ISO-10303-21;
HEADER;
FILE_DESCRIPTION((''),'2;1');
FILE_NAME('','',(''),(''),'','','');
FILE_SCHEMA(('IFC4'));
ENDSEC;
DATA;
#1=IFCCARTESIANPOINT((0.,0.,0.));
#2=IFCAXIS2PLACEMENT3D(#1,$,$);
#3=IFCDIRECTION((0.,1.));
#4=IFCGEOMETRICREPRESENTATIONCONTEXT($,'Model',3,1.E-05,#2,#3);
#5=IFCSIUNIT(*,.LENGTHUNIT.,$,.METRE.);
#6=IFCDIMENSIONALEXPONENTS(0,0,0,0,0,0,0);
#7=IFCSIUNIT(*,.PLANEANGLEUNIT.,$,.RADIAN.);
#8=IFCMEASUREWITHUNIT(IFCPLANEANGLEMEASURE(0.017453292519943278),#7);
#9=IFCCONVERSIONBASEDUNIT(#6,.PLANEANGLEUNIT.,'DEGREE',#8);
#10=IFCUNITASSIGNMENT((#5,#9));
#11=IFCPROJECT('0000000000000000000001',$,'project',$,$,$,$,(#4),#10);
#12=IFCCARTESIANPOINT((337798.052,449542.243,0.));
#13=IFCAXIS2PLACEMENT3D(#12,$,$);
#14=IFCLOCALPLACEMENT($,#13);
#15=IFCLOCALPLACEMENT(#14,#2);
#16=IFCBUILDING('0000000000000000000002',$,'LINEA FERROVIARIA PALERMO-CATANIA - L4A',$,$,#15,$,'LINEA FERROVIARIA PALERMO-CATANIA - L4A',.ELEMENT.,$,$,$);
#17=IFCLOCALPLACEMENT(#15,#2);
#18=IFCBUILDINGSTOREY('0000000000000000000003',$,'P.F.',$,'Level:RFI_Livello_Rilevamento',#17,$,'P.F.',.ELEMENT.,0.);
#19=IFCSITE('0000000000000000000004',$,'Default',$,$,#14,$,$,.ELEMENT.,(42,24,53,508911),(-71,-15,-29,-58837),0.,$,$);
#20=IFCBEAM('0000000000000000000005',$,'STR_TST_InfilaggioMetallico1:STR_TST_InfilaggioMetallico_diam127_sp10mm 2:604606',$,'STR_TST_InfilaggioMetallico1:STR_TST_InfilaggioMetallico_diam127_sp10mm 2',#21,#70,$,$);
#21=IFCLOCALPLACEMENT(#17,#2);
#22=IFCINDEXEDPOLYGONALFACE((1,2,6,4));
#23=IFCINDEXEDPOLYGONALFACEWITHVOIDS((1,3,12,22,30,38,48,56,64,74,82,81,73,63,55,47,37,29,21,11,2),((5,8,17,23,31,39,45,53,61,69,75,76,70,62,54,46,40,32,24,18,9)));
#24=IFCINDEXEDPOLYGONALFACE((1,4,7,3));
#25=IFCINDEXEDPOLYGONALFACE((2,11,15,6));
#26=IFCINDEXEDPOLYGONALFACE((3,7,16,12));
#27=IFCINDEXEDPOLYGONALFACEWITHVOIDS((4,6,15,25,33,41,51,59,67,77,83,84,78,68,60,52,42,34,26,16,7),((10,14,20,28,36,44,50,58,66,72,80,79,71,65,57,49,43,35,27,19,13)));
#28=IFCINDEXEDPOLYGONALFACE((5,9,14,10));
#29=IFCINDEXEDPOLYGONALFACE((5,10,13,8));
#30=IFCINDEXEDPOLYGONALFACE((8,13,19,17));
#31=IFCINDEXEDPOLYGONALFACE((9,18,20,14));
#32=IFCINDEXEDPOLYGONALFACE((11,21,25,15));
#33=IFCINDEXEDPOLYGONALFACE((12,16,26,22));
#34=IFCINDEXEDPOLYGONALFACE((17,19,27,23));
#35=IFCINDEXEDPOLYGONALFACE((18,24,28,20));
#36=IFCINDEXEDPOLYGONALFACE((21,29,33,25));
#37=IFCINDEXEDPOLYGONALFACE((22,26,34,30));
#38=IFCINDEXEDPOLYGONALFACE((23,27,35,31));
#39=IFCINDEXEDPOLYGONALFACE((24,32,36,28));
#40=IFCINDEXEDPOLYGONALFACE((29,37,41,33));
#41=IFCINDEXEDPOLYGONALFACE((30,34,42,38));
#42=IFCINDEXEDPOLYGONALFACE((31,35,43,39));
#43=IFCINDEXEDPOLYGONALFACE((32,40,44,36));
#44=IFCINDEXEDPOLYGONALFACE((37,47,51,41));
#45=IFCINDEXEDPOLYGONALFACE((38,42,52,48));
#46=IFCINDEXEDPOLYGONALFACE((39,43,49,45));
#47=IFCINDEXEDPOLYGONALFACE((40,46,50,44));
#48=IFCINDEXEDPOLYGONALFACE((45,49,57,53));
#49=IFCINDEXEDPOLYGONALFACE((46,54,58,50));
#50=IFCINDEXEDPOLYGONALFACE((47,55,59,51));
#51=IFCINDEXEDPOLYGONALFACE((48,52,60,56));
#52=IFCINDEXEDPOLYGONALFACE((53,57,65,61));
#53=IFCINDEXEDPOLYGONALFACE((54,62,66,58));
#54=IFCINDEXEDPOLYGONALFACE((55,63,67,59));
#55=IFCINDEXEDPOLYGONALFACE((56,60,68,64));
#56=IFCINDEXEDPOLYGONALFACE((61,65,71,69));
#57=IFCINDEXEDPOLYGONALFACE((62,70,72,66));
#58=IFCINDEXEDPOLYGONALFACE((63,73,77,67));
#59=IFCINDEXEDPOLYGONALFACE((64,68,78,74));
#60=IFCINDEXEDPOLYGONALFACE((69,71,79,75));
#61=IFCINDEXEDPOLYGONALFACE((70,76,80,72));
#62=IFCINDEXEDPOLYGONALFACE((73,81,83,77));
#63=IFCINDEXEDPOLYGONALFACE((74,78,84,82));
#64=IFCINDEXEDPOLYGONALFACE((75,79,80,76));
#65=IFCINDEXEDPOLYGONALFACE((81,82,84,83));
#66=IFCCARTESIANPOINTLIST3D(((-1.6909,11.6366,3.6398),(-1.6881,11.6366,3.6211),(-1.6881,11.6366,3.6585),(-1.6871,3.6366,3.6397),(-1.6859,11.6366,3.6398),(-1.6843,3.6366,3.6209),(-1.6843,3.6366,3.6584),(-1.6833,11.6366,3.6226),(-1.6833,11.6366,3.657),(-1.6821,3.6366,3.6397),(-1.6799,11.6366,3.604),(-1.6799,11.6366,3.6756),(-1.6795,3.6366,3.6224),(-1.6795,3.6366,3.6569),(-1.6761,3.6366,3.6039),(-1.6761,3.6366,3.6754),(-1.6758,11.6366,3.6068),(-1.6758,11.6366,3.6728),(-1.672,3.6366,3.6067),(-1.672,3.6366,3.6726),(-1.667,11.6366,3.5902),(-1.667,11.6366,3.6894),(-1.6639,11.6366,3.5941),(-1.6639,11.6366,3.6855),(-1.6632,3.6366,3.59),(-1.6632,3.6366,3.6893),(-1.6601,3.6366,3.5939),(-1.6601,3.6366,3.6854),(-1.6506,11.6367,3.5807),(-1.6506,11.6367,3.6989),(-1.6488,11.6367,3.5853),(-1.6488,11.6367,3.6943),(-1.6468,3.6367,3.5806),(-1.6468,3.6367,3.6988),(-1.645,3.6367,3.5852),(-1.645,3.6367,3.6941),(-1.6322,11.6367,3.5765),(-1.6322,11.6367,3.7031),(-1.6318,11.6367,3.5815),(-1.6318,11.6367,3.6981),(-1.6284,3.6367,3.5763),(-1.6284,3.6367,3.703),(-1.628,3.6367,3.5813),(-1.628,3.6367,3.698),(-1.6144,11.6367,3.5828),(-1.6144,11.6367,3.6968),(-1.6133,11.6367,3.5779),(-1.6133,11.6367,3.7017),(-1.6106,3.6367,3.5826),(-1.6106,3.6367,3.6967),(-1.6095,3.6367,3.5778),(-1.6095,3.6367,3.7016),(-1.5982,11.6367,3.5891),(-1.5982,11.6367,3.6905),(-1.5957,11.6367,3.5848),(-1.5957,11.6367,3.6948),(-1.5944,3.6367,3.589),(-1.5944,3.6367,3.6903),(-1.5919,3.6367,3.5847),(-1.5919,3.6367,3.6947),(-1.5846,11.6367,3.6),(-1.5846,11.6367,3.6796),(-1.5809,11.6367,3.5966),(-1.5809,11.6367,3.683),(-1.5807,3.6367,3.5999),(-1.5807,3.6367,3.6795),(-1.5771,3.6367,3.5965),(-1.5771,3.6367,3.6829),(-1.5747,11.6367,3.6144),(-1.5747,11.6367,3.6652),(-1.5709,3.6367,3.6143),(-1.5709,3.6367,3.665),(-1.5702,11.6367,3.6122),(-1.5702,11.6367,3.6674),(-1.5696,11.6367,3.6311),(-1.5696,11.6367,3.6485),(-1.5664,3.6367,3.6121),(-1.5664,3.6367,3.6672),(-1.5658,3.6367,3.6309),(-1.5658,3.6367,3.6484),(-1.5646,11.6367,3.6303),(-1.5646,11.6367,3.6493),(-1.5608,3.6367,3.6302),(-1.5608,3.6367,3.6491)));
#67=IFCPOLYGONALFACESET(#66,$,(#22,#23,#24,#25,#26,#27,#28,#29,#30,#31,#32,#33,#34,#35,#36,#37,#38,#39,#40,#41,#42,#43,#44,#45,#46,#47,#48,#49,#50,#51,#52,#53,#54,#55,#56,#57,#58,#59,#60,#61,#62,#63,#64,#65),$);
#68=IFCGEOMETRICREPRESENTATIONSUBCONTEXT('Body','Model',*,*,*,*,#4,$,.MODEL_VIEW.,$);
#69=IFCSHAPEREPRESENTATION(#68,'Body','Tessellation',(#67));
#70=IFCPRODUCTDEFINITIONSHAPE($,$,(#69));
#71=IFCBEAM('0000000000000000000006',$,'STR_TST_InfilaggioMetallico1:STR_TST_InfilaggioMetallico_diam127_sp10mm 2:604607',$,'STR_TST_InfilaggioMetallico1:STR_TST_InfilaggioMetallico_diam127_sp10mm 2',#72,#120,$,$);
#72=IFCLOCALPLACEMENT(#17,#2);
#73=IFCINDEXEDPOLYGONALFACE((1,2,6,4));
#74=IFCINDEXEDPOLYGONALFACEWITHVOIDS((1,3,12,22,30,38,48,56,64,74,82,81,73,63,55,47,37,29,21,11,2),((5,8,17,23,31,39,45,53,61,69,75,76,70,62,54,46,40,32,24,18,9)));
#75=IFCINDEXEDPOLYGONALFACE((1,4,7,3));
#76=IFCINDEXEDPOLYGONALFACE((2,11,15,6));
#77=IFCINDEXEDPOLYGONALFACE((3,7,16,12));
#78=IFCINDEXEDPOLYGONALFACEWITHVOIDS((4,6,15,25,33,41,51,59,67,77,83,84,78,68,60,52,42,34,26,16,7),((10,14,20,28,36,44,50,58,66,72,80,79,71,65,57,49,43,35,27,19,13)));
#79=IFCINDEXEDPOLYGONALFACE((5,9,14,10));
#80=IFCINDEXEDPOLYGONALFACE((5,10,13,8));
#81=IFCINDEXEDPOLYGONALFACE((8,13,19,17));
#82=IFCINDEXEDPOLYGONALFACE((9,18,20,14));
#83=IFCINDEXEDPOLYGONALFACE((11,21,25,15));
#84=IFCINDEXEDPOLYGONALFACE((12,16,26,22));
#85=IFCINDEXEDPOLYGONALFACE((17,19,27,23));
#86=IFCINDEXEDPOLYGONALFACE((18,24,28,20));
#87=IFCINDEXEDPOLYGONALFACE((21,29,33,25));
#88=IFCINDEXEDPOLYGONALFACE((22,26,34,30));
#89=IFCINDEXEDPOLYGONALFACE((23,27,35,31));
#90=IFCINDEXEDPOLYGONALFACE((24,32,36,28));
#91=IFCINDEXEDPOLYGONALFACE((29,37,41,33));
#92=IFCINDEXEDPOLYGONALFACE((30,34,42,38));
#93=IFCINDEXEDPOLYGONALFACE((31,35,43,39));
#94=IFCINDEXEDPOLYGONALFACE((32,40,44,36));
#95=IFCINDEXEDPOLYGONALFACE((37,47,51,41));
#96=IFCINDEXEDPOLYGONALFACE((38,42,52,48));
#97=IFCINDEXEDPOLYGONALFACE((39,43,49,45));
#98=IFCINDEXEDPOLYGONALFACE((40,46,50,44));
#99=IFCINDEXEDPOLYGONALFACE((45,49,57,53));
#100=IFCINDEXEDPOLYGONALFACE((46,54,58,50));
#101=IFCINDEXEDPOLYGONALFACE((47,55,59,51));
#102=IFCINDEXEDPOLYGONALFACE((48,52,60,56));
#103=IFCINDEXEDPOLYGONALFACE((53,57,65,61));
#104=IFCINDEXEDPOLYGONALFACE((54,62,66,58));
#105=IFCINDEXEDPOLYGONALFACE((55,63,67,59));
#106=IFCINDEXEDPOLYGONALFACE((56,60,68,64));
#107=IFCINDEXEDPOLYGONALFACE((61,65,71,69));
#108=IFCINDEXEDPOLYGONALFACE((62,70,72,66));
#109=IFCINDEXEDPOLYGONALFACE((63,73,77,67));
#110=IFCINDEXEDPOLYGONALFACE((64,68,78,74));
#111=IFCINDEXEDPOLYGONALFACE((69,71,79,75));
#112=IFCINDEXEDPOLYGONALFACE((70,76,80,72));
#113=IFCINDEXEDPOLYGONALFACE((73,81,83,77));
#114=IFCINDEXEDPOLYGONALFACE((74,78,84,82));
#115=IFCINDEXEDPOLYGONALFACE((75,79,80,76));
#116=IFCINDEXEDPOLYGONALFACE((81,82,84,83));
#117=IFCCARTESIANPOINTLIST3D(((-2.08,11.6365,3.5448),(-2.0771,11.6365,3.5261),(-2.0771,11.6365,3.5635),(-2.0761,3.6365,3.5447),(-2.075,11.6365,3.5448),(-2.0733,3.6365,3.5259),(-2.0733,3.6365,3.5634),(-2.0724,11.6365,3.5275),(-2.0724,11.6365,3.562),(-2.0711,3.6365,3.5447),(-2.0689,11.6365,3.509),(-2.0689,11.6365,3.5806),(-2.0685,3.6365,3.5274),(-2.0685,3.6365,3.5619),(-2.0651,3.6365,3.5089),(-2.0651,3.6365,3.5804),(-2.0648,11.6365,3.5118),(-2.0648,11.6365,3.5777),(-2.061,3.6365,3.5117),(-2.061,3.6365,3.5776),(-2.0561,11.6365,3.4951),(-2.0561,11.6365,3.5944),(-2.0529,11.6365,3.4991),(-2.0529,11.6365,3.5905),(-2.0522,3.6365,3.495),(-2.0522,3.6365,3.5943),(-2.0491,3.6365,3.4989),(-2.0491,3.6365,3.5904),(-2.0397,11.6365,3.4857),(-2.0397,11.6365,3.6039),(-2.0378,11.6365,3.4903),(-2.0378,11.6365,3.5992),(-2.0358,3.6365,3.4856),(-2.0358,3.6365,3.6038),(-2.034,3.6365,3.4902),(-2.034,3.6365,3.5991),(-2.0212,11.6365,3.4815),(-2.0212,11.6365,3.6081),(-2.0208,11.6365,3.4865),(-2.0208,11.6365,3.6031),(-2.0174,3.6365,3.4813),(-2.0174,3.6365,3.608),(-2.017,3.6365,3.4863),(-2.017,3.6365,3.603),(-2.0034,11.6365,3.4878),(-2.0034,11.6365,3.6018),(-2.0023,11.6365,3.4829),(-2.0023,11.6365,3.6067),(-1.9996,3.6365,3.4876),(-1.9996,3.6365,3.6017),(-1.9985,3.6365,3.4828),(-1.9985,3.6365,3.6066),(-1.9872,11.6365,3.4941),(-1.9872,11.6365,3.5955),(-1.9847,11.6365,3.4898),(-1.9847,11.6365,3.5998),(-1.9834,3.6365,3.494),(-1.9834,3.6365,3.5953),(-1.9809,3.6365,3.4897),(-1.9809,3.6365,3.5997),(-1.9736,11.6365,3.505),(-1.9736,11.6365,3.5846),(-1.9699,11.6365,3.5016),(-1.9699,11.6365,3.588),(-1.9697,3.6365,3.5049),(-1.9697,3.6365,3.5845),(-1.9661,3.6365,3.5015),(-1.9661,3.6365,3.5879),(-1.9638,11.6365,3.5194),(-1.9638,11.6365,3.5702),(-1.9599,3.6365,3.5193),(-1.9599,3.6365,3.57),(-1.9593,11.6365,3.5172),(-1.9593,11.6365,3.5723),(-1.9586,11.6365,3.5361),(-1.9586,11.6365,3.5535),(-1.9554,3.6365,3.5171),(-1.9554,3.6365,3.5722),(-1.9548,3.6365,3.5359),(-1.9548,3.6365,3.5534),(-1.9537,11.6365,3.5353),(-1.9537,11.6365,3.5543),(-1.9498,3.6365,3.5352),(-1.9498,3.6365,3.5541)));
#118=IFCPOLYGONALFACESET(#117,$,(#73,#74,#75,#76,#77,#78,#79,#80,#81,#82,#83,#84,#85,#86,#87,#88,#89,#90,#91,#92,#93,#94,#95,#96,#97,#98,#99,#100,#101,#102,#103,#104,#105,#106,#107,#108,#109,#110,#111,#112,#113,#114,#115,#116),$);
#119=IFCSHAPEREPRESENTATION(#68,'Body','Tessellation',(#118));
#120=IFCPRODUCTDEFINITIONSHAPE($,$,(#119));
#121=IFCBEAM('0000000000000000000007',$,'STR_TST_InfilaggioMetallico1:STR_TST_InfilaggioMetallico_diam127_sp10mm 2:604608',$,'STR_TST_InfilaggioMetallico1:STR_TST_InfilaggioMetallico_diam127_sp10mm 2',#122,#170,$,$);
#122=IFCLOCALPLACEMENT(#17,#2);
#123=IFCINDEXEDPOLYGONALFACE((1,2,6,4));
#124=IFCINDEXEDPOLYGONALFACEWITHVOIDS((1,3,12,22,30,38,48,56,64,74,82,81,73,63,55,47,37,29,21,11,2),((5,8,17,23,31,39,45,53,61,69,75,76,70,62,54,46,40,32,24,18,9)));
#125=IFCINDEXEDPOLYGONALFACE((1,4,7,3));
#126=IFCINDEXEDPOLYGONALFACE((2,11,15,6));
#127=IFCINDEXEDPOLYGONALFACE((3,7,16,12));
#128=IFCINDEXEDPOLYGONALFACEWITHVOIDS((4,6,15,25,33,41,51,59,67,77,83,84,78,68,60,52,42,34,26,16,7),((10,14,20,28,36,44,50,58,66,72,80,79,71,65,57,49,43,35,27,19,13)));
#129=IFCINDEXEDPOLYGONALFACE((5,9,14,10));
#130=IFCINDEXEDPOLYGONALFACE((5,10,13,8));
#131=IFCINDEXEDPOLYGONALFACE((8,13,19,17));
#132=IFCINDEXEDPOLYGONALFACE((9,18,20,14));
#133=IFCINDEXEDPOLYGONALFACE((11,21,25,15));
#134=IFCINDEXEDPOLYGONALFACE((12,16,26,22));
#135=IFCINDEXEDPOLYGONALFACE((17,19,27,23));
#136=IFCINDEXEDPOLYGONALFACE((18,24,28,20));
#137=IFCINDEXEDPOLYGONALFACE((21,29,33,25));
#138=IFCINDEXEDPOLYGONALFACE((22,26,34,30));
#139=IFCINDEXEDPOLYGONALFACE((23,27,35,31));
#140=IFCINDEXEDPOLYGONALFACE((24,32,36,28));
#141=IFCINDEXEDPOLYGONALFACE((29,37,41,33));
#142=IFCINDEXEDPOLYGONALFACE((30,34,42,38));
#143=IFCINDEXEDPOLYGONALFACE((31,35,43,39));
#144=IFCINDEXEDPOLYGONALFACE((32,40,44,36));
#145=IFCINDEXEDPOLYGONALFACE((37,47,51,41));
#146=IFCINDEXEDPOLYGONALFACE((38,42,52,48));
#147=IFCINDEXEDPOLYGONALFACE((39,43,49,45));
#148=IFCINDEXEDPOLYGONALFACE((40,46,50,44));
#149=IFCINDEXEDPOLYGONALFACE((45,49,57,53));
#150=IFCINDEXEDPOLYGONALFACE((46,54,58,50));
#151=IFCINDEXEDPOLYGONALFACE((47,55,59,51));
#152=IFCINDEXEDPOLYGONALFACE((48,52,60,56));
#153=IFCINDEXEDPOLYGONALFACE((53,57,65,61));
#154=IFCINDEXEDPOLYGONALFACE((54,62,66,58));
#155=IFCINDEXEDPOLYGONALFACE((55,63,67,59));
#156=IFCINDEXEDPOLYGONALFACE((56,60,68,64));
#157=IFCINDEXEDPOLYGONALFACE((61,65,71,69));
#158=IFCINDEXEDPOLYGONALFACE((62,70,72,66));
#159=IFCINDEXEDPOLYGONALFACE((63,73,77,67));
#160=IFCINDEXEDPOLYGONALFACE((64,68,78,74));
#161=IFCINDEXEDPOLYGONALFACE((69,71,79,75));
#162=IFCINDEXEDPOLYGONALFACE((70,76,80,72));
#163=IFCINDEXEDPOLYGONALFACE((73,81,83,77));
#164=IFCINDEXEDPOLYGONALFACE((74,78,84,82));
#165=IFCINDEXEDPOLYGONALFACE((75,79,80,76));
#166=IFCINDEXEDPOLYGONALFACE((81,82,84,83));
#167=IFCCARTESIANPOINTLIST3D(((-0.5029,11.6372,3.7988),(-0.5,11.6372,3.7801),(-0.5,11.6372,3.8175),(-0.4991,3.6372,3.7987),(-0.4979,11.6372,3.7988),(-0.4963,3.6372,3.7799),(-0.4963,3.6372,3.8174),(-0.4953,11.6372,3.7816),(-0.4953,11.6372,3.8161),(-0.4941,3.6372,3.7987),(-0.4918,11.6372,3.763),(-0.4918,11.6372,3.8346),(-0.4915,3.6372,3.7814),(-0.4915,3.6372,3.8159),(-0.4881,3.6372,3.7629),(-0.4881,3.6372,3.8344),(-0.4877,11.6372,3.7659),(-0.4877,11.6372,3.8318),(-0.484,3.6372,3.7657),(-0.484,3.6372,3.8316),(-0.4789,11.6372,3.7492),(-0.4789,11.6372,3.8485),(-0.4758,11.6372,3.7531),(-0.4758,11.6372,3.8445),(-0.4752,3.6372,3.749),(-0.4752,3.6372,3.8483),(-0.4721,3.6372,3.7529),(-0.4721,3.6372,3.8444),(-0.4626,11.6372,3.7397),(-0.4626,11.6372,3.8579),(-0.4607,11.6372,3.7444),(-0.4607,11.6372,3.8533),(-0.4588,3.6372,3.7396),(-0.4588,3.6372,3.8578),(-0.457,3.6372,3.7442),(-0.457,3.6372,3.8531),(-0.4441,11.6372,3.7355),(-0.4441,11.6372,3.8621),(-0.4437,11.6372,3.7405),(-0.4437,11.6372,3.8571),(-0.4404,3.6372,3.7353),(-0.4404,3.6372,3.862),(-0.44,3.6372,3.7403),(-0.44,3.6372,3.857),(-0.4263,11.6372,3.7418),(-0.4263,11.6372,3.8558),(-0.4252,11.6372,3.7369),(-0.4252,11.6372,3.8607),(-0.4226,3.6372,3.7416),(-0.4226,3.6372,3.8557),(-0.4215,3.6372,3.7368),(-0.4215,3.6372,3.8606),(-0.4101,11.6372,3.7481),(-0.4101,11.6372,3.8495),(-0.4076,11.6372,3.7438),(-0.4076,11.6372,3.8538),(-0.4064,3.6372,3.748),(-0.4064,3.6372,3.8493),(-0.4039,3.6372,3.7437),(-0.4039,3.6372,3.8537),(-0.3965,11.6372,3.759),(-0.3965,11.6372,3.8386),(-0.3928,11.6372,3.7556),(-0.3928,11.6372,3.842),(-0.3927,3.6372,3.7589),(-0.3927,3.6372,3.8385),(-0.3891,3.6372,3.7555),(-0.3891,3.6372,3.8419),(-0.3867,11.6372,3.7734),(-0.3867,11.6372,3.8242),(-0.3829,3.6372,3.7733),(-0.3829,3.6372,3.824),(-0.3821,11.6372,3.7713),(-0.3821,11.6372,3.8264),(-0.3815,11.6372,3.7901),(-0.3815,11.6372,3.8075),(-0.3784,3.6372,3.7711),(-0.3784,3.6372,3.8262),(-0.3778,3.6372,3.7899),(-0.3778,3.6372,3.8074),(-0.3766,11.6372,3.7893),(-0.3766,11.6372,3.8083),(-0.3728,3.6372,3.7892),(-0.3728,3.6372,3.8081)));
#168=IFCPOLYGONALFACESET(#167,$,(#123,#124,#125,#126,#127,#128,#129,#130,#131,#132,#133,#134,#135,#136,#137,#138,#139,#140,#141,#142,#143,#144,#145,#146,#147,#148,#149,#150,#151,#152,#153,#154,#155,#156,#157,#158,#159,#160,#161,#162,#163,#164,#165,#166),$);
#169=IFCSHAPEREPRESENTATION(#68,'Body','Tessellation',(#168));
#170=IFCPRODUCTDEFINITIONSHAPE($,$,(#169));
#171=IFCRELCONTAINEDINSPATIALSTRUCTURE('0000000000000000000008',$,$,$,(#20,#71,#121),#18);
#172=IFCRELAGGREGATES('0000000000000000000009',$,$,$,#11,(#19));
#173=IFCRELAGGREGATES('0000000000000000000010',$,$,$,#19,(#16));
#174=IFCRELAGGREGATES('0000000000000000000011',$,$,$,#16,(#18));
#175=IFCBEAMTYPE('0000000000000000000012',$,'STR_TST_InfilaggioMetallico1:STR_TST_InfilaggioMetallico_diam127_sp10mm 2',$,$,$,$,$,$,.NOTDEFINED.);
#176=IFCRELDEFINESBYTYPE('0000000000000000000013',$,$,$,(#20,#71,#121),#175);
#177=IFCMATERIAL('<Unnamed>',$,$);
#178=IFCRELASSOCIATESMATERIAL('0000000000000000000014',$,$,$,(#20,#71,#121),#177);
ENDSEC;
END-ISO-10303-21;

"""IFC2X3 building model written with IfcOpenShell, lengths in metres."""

from ifc_helpers import new_model, entity, si_unit, converted_unit, direction, frame, origin, origin_2d_with_axis, place, context, subcontext, project, spatial, hollow_circle, extrude, material, type_object, element, save


model = new_model("IFC2X3")

# Units and contexts
model_context = context("Model", 3, precision=1e-05, world=origin(), true_north=direction((0.0, 1.0)))
body_context = subcontext(model_context, "Body", "Model", "MODEL_VIEW")
ifc_project = project(units=[si_unit("LENGTHUNIT", "METRE"), converted_unit("PLANEANGLEUNIT", "DEGREE", entity("IfcPlaneAngleMeasure", 0.017453292519943278), si_unit("PLANEANGLEUNIT", "RADIAN"), dimensions=[0, 0, 0, 0, 0, 0, 0])], contexts=[model_context])

# Site, building, storey
site_placement = place(None, frame((337798.052, 449542.243, 0.0)))
site = spatial("IfcSite", under=ifc_project, at=site_placement, Name="Default", CompositionType="ELEMENT", RefLatitude=(42, 24, 53, 508911), RefLongitude=(-71, -15, -29, -58837), RefElevation=0.0)
building_placement = place(site_placement, origin())
building = spatial("IfcBuilding", under=site, at=building_placement, Name="LINEA FERROVIARIA PALERMO-CATANIA - L4A", LongName="LINEA FERROVIARIA PALERMO-CATANIA - L4A", CompositionType="ELEMENT")
storey_placement = place(building_placement, origin())
storey = spatial("IfcBuildingStorey", under=building, at=storey_placement, Name="P.F.", ObjectType="Level:RFI_Livello_Rilevamento", LongName="P.F.", CompositionType="ELEMENT", Elevation=0.0)

# Beams
ifc_material = material(Name="<Unnamed>")
beam_type = type_object("IfcBeamType", Name="STR_TST_InfilaggioMetallico1:STR_TST_InfilaggioMetallico_diam127_sp10mm 2", PredefinedType="NOTDEFINED")
beam_1_placement = place(storey_placement, frame((-1.6925, 3.6366, 3.7049), z_axis=(0.0, -0.000017, 1.0), x_axis=(-0.000477, 1.0, 0.000017)))
element("IfcBeam", 1, at=beam_1_placement, inside=storey, type_object=beam_type, material=ifc_material, Name="STR_TST_InfilaggioMetallico1:STR_TST_InfilaggioMetallico_diam127_sp10mm 2:604606", ObjectType="STR_TST_InfilaggioMetallico1:STR_TST_InfilaggioMetallico_diam127_sp10mm 2", context=body_context, shape_type="SweptSolid", body=[
    extrude(hollow_circle(Radius=0.0635, WallThickness=0.005, at=origin_2d_with_axis()), frame((0.0, -0.0689, -0.0652), z_axis=(1.0, 0.0, 0.0), x_axis=(0.0, 1.0, 0.0)), (0.0, 0.0, 1.0), 8.0),
])
beam_2_placement = place(storey_placement, frame((-2.0816, 3.6365, 3.6099), z_axis=(0.0, -0.000016, 1.0), x_axis=(-0.00048, 1.0, 0.000016)))
element("IfcBeam", 2, at=beam_2_placement, inside=storey, type_object=beam_type, material=ifc_material, Name="STR_TST_InfilaggioMetallico1:STR_TST_InfilaggioMetallico_diam127_sp10mm 2:604607", ObjectType="STR_TST_InfilaggioMetallico1:STR_TST_InfilaggioMetallico_diam127_sp10mm 2", context=body_context, shape_type="SweptSolid", body=[
    extrude(hollow_circle(Radius=0.0635, WallThickness=0.005, at=origin_2d_with_axis()), frame((0.0, -0.0689, -0.0652), z_axis=(1.0, 0.0, 0.0), x_axis=(0.0, 1.0, 0.0)), (0.0, 0.0, 1.0), 8.0),
])
beam_3_placement = place(storey_placement, frame((-0.5044, 3.6372, 3.8639), z_axis=(0.0, -0.000019, 1.0), x_axis=(-0.000466, 1.0, 0.000019)))
element("IfcBeam", 3, at=beam_3_placement, inside=storey, type_object=beam_type, material=ifc_material, Name="STR_TST_InfilaggioMetallico1:STR_TST_InfilaggioMetallico_diam127_sp10mm 2:604608", ObjectType="STR_TST_InfilaggioMetallico1:STR_TST_InfilaggioMetallico_diam127_sp10mm 2", context=body_context, shape_type="SweptSolid", body=[
    extrude(hollow_circle(Radius=0.0635, WallThickness=0.005, at=origin_2d_with_axis()), frame((0.0, -0.0688, -0.0652), z_axis=(1.0, 0.0, 0.0), x_axis=(0.0, 1.0, 0.0)), (0.0, 0.0, 1.0), 8.0),
])

save(model, "model.ifc")
